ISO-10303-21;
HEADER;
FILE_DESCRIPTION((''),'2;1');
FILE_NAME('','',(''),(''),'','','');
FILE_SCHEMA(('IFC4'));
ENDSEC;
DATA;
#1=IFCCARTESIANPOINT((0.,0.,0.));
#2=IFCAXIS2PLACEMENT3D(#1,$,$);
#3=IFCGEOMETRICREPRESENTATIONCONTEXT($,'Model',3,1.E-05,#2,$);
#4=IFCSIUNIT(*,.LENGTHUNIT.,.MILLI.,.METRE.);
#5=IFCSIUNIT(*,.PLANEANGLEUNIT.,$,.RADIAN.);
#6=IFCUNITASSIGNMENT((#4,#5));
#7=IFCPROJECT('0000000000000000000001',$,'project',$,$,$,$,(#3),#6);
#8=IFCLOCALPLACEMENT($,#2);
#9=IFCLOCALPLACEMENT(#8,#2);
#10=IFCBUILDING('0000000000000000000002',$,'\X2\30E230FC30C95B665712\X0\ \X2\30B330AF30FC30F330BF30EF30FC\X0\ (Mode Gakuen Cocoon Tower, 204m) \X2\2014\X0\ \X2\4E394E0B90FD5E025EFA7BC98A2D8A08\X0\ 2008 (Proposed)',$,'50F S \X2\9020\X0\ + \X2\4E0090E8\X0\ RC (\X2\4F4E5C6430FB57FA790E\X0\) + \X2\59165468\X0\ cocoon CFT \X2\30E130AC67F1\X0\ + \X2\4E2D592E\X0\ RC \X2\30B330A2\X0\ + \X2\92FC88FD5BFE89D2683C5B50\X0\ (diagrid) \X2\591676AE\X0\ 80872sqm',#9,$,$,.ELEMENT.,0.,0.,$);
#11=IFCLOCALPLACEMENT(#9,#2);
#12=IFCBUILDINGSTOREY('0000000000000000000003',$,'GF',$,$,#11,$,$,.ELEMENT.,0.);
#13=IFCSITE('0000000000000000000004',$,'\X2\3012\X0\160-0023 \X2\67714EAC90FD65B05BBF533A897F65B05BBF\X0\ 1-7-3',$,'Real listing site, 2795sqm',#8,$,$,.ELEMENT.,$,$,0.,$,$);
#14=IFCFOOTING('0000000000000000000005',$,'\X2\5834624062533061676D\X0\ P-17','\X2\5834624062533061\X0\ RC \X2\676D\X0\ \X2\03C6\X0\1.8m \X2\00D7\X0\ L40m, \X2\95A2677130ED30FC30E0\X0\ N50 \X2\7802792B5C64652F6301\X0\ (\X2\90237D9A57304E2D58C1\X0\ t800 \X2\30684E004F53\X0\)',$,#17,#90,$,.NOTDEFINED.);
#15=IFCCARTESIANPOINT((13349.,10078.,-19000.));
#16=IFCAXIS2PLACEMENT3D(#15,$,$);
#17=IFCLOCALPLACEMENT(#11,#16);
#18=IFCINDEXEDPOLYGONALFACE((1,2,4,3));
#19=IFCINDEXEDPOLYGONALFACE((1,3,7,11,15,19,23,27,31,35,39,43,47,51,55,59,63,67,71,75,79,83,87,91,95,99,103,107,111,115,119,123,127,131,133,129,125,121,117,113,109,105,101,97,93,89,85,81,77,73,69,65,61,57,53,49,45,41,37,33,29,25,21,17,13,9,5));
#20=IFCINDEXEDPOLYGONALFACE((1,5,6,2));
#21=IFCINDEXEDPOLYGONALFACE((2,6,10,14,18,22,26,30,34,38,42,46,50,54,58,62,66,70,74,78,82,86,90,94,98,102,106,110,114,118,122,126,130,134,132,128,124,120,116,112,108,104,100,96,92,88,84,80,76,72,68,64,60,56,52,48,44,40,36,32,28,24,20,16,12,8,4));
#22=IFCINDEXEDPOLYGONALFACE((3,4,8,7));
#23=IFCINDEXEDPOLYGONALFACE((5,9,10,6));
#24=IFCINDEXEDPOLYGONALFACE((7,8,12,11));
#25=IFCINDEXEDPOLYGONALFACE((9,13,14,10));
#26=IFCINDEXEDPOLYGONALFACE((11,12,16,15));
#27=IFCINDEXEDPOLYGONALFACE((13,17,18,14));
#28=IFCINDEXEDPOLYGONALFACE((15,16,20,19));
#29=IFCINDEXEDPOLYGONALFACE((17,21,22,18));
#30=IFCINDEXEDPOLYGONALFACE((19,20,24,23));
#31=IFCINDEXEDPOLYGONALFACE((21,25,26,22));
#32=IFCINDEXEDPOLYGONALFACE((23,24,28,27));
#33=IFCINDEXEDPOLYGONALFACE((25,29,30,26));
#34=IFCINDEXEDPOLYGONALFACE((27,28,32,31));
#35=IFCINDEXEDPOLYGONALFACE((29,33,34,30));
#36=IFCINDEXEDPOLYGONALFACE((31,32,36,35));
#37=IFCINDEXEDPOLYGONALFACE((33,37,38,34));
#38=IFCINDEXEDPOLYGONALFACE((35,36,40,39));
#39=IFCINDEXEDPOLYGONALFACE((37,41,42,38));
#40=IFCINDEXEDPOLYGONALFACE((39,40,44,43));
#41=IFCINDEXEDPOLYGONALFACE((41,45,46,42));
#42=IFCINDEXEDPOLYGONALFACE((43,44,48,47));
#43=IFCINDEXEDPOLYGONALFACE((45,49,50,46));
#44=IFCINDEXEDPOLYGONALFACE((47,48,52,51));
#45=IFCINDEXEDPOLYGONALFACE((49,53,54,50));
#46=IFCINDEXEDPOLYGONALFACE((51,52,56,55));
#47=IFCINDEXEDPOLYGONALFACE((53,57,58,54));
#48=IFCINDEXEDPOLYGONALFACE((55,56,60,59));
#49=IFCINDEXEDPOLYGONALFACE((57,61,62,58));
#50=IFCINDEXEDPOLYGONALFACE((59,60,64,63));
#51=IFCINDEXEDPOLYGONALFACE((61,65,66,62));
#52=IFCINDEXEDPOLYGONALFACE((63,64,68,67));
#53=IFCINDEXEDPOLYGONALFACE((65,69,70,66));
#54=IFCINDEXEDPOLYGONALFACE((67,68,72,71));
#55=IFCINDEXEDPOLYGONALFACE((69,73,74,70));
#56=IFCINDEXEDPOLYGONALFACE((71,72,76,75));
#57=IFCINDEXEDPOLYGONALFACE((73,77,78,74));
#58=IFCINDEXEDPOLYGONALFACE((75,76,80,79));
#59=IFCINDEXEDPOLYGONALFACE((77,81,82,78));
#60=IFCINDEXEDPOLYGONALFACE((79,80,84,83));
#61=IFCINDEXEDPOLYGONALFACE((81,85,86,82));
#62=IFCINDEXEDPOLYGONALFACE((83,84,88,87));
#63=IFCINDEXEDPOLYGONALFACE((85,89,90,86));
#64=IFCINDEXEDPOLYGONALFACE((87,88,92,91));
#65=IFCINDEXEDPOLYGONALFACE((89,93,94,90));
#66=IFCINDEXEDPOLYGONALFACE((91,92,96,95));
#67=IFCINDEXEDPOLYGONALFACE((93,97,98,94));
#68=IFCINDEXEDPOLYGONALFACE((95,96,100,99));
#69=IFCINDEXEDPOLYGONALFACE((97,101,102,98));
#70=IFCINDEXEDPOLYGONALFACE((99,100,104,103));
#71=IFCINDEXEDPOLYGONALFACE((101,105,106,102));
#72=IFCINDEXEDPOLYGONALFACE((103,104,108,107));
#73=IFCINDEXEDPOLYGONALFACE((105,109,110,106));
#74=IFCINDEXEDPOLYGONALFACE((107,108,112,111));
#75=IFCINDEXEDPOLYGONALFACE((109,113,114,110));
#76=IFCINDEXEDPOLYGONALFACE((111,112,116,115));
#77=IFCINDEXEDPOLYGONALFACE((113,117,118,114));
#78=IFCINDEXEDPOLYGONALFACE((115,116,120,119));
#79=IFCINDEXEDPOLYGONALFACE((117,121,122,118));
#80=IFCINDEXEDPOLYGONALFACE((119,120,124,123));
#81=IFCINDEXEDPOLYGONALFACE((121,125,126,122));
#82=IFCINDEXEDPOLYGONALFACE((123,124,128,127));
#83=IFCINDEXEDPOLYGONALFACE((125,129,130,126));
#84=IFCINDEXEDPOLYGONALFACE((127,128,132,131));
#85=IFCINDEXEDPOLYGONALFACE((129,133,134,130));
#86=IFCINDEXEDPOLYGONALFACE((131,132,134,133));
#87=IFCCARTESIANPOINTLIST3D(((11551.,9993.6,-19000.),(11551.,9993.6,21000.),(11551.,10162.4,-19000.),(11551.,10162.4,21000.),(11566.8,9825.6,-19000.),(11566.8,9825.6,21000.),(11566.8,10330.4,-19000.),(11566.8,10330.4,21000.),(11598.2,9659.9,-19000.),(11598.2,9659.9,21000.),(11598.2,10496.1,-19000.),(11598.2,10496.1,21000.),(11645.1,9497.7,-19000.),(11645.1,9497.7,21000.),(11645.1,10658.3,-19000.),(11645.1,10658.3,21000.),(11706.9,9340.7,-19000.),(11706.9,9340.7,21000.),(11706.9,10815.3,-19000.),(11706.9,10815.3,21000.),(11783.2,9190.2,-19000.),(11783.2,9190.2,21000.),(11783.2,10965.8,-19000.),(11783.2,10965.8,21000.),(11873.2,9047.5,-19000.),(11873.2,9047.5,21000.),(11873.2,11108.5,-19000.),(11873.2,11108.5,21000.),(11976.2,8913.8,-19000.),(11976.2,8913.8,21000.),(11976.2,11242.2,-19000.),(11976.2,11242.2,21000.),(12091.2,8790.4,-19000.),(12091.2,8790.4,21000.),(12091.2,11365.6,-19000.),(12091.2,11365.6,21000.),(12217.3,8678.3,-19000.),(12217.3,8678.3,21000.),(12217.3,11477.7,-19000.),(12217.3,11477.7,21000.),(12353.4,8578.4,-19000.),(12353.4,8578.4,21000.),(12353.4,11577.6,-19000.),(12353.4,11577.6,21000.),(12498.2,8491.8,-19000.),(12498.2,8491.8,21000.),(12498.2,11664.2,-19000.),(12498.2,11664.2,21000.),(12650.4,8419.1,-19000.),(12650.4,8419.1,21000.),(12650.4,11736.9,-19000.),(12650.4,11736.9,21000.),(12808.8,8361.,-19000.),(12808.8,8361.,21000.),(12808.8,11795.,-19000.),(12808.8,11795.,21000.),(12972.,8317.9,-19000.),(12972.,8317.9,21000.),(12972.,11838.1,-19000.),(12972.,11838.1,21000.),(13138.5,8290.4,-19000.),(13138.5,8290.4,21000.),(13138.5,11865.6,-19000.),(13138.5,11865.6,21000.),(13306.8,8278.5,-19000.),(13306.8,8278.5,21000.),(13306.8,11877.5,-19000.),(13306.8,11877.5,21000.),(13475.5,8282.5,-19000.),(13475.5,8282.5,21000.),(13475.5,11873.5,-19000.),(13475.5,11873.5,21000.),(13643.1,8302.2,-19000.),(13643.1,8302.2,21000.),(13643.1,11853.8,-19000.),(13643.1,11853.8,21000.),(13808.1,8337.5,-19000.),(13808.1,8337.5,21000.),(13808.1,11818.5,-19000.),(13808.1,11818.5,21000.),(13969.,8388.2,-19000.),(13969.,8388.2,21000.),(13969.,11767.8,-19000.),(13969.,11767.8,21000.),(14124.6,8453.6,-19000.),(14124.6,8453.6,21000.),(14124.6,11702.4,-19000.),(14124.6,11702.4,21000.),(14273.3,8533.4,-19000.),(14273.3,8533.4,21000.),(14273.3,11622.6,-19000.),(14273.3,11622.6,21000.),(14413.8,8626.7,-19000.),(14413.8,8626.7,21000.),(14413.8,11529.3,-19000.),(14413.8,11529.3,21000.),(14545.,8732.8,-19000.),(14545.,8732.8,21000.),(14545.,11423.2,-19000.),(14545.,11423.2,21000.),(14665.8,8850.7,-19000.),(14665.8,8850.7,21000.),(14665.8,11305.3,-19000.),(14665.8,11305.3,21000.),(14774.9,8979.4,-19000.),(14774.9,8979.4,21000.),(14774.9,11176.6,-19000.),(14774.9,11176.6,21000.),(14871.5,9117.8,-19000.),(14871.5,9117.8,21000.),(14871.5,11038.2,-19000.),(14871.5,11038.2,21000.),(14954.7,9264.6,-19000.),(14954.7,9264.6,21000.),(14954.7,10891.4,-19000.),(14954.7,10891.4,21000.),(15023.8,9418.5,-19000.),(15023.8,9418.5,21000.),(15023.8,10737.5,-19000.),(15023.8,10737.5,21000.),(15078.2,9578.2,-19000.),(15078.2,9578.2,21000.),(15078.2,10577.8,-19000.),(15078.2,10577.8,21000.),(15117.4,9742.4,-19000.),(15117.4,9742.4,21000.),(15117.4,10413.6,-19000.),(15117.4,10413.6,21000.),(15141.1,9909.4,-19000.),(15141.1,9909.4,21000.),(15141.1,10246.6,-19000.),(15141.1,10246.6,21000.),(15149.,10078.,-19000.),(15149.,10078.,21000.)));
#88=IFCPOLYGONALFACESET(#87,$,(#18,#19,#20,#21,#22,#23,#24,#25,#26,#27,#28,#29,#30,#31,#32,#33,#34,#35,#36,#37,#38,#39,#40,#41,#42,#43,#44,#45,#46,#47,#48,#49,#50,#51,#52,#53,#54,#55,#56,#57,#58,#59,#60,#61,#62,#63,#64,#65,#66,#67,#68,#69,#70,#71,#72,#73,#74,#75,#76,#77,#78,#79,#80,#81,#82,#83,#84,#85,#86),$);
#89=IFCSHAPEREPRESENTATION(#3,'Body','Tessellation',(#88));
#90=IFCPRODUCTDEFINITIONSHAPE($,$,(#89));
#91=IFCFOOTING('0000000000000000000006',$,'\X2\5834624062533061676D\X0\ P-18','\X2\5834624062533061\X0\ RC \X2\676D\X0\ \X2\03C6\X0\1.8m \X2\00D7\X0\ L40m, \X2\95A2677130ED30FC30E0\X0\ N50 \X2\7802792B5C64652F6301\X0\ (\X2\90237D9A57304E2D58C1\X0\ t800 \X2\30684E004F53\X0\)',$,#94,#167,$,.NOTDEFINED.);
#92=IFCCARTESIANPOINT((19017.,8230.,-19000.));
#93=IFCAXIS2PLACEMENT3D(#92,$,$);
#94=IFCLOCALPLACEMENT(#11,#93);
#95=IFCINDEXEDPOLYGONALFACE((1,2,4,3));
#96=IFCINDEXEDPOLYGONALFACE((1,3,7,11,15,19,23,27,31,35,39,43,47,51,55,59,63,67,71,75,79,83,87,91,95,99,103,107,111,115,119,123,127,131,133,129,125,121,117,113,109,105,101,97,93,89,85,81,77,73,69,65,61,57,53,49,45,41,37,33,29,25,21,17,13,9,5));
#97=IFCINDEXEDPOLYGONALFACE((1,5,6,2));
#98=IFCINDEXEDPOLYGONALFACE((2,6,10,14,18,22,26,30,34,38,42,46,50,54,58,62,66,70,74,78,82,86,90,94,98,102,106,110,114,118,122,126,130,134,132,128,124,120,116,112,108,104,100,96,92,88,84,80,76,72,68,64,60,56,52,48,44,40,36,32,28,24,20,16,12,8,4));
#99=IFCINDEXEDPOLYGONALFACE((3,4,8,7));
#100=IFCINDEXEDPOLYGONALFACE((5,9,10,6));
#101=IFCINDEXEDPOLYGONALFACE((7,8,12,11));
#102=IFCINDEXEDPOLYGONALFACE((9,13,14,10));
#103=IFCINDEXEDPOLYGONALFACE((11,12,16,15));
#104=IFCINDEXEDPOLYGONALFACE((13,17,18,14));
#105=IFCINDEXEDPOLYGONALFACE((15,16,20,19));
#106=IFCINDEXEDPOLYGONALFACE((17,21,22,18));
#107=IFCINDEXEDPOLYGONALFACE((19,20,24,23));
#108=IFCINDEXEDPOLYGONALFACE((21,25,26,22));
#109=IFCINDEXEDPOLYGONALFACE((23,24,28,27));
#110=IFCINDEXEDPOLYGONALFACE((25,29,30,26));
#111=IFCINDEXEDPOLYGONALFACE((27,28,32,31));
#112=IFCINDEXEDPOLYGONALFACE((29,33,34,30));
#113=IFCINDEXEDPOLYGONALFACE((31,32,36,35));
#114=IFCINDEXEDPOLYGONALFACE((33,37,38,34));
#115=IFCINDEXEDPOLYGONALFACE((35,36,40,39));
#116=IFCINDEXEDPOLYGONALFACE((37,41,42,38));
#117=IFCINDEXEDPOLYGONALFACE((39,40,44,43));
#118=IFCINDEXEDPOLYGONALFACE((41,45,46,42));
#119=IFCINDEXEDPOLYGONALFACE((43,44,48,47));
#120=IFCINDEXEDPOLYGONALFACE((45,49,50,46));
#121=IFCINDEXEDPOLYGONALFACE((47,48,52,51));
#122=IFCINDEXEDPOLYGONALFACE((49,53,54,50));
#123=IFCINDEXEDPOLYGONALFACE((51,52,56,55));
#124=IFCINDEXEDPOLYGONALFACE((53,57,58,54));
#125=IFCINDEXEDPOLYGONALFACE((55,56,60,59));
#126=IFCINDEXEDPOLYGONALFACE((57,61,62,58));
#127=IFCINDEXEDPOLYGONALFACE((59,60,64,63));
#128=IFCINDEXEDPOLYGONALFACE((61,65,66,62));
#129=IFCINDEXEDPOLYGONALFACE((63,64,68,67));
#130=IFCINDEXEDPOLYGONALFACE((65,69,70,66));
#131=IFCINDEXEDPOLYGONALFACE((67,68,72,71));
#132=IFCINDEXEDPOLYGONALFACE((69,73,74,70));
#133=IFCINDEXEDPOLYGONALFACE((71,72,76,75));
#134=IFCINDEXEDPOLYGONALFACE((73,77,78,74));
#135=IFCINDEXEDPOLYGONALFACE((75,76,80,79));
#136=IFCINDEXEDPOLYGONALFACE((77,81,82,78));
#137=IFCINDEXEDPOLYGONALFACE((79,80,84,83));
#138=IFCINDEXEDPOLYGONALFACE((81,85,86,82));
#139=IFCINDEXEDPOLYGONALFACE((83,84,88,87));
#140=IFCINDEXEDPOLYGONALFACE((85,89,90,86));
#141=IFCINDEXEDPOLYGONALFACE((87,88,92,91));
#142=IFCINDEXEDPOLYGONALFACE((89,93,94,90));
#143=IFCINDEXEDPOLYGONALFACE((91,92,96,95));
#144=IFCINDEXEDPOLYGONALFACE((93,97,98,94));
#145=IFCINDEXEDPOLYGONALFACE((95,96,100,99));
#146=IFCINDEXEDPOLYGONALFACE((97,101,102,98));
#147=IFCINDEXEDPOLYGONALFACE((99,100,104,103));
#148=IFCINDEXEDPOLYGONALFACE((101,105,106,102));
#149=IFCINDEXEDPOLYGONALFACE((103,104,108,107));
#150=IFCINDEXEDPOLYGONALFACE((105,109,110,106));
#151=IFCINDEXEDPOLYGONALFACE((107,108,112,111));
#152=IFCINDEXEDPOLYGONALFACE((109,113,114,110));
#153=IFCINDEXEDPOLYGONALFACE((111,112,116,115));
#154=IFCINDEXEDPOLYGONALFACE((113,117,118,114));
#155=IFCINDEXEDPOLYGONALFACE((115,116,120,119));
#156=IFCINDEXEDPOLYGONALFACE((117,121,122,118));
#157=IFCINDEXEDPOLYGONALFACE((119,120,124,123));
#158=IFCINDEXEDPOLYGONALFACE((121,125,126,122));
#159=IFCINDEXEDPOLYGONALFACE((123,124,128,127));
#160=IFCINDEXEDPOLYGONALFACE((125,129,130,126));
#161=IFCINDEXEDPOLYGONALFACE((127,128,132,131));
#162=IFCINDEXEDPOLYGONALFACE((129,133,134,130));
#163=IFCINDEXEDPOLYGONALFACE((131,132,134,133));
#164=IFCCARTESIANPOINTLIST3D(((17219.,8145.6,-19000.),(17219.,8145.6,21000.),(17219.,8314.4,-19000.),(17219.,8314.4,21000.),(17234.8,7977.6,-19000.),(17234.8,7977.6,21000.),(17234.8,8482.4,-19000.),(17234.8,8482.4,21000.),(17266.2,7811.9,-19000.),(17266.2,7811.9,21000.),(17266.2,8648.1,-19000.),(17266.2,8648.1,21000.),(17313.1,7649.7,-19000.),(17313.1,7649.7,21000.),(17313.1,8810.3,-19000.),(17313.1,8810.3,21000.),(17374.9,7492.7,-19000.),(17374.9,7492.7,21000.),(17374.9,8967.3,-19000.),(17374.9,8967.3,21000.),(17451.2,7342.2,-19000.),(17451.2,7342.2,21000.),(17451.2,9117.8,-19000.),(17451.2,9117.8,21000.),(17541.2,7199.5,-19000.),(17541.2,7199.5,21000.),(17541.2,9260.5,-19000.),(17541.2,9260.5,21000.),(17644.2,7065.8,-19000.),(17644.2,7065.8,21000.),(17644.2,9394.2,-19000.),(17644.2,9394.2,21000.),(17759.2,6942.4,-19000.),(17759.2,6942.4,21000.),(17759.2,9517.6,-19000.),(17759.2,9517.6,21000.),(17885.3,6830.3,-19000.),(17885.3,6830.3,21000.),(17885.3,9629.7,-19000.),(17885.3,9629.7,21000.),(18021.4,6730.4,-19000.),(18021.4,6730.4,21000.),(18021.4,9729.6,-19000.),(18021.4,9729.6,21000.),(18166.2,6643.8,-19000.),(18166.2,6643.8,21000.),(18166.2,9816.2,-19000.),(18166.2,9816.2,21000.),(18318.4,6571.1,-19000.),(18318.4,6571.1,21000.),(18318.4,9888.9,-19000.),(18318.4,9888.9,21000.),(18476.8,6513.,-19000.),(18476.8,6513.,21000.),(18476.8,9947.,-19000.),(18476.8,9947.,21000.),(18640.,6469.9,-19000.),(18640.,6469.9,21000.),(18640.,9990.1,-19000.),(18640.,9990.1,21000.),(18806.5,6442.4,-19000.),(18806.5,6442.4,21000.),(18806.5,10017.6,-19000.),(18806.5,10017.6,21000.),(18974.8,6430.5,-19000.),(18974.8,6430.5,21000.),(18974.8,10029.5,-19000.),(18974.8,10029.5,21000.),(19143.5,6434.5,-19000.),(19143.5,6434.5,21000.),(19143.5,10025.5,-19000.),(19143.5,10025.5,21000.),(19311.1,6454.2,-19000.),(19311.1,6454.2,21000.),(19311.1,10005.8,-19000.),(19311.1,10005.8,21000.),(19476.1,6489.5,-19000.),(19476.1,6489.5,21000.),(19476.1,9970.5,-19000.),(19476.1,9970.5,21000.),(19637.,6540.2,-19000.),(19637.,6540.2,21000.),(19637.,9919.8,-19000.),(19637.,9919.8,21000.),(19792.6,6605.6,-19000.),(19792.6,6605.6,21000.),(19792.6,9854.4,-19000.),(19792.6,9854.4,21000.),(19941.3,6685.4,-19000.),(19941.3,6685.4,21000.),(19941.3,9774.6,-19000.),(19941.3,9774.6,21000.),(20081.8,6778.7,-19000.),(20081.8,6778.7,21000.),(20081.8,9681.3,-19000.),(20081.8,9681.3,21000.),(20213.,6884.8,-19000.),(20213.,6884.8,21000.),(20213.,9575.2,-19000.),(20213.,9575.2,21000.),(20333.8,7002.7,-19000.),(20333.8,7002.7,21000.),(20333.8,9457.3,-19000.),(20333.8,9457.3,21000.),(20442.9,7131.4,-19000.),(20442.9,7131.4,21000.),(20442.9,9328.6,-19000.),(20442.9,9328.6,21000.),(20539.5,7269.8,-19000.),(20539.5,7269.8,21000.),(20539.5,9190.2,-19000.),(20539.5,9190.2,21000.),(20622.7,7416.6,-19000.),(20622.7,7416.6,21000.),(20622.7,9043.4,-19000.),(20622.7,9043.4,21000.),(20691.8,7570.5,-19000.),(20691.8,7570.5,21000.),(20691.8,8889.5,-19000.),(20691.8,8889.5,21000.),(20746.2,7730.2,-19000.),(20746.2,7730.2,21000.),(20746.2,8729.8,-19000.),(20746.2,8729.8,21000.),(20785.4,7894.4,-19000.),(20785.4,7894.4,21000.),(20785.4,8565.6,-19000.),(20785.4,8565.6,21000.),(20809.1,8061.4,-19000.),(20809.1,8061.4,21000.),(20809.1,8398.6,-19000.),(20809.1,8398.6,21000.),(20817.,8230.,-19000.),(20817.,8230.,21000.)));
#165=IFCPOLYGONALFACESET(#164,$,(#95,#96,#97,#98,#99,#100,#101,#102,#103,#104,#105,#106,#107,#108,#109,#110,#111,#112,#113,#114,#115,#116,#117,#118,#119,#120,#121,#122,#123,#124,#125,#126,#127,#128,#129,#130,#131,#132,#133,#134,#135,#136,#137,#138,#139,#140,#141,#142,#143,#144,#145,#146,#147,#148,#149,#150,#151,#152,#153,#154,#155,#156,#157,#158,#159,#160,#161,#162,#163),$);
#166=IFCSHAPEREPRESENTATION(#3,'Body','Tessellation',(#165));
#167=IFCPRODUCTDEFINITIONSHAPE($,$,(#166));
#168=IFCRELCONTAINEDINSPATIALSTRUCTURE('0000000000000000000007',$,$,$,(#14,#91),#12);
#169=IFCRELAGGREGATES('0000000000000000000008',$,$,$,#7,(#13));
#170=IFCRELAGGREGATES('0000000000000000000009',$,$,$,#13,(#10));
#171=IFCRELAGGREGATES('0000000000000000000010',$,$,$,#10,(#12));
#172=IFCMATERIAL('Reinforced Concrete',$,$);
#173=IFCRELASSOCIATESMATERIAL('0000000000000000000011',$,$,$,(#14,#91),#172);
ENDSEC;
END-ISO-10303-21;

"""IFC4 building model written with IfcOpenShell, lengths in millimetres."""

from ifc_helpers import new_model, si_unit, frame, origin, origin_2d, place, context, project, spatial, circle, extrude, material, element, save


model = new_model("IFC4")

# Units and contexts
model_context = context("Model", 3, precision=1e-05, world=origin())
ifc_project = project(units=[si_unit("LENGTHUNIT", "METRE", prefix="MILLI"), si_unit("PLANEANGLEUNIT", "RADIAN")], contexts=[model_context])

# Site, building, storey
site_placement = place(None, origin())
site = spatial("IfcSite", under=ifc_project, at=site_placement, Name="〒160-0023 東京都新宿区西新宿 1-7-3", ObjectType="Real listing site, 2795sqm", CompositionType="ELEMENT", RefElevation=0.0)
building_placement = place(site_placement, origin())
building = spatial("IfcBuilding", under=site, at=building_placement, Name="モード学園 コクーンタワー (Mode Gakuen Cocoon Tower, 204m) — 丹下都市建築設計 2008 (Proposed)", ObjectType="50F S 造 + 一部 RC (低層・基礎) + 外周 cocoon CFT メガ柱 + 中央 RC コア + 鋼製対角格子 (diagrid) 外皮 80872sqm", CompositionType="ELEMENT", ElevationOfRefHeight=0.0, ElevationOfTerrain=0.0)
storey_placement = place(building_placement, origin())
storey = spatial("IfcBuildingStorey", under=building, at=storey_placement, Name="GF", CompositionType="ELEMENT", Elevation=0.0)

# Footings
ifc_material_1 = material(Name="Reinforced Concrete")
footing_1_placement = place(storey_placement, frame((13349.0, 10078.0, -19000.0)))
element("IfcFooting", 1, at=footing_1_placement, inside=storey, material=ifc_material_1, Name="場所打ち杭 P-17", Description="場所打ち RC 杭 φ1.8m × L40m, 関東ローム N50 砂礫層支持 (連続地中壁 t800 と一体)", PredefinedType="NOTDEFINED", context=model_context, shape_type="SweptSolid", body=[
    extrude(circle(Radius=1800.0, at=origin_2d()), frame((13349.0, 10078.0, -19000.0)), (0.0, 0.0, 1.0), 40000.0),
])
footing_2_placement = place(storey_placement, frame((19017.0, 8230.0, -19000.0)))
element("IfcFooting", 2, at=footing_2_placement, inside=storey, material=ifc_material_1, Name="場所打ち杭 P-18", Description="場所打ち RC 杭 φ1.8m × L40m, 関東ローム N50 砂礫層支持 (連続地中壁 t800 と一体)", PredefinedType="NOTDEFINED", context=model_context, shape_type="SweptSolid", body=[
    extrude(circle(Radius=1800.0, at=origin_2d()), frame((19017.0, 8230.0, -19000.0)), (0.0, 0.0, 1.0), 40000.0),
])

save(model, "model.ifc")
